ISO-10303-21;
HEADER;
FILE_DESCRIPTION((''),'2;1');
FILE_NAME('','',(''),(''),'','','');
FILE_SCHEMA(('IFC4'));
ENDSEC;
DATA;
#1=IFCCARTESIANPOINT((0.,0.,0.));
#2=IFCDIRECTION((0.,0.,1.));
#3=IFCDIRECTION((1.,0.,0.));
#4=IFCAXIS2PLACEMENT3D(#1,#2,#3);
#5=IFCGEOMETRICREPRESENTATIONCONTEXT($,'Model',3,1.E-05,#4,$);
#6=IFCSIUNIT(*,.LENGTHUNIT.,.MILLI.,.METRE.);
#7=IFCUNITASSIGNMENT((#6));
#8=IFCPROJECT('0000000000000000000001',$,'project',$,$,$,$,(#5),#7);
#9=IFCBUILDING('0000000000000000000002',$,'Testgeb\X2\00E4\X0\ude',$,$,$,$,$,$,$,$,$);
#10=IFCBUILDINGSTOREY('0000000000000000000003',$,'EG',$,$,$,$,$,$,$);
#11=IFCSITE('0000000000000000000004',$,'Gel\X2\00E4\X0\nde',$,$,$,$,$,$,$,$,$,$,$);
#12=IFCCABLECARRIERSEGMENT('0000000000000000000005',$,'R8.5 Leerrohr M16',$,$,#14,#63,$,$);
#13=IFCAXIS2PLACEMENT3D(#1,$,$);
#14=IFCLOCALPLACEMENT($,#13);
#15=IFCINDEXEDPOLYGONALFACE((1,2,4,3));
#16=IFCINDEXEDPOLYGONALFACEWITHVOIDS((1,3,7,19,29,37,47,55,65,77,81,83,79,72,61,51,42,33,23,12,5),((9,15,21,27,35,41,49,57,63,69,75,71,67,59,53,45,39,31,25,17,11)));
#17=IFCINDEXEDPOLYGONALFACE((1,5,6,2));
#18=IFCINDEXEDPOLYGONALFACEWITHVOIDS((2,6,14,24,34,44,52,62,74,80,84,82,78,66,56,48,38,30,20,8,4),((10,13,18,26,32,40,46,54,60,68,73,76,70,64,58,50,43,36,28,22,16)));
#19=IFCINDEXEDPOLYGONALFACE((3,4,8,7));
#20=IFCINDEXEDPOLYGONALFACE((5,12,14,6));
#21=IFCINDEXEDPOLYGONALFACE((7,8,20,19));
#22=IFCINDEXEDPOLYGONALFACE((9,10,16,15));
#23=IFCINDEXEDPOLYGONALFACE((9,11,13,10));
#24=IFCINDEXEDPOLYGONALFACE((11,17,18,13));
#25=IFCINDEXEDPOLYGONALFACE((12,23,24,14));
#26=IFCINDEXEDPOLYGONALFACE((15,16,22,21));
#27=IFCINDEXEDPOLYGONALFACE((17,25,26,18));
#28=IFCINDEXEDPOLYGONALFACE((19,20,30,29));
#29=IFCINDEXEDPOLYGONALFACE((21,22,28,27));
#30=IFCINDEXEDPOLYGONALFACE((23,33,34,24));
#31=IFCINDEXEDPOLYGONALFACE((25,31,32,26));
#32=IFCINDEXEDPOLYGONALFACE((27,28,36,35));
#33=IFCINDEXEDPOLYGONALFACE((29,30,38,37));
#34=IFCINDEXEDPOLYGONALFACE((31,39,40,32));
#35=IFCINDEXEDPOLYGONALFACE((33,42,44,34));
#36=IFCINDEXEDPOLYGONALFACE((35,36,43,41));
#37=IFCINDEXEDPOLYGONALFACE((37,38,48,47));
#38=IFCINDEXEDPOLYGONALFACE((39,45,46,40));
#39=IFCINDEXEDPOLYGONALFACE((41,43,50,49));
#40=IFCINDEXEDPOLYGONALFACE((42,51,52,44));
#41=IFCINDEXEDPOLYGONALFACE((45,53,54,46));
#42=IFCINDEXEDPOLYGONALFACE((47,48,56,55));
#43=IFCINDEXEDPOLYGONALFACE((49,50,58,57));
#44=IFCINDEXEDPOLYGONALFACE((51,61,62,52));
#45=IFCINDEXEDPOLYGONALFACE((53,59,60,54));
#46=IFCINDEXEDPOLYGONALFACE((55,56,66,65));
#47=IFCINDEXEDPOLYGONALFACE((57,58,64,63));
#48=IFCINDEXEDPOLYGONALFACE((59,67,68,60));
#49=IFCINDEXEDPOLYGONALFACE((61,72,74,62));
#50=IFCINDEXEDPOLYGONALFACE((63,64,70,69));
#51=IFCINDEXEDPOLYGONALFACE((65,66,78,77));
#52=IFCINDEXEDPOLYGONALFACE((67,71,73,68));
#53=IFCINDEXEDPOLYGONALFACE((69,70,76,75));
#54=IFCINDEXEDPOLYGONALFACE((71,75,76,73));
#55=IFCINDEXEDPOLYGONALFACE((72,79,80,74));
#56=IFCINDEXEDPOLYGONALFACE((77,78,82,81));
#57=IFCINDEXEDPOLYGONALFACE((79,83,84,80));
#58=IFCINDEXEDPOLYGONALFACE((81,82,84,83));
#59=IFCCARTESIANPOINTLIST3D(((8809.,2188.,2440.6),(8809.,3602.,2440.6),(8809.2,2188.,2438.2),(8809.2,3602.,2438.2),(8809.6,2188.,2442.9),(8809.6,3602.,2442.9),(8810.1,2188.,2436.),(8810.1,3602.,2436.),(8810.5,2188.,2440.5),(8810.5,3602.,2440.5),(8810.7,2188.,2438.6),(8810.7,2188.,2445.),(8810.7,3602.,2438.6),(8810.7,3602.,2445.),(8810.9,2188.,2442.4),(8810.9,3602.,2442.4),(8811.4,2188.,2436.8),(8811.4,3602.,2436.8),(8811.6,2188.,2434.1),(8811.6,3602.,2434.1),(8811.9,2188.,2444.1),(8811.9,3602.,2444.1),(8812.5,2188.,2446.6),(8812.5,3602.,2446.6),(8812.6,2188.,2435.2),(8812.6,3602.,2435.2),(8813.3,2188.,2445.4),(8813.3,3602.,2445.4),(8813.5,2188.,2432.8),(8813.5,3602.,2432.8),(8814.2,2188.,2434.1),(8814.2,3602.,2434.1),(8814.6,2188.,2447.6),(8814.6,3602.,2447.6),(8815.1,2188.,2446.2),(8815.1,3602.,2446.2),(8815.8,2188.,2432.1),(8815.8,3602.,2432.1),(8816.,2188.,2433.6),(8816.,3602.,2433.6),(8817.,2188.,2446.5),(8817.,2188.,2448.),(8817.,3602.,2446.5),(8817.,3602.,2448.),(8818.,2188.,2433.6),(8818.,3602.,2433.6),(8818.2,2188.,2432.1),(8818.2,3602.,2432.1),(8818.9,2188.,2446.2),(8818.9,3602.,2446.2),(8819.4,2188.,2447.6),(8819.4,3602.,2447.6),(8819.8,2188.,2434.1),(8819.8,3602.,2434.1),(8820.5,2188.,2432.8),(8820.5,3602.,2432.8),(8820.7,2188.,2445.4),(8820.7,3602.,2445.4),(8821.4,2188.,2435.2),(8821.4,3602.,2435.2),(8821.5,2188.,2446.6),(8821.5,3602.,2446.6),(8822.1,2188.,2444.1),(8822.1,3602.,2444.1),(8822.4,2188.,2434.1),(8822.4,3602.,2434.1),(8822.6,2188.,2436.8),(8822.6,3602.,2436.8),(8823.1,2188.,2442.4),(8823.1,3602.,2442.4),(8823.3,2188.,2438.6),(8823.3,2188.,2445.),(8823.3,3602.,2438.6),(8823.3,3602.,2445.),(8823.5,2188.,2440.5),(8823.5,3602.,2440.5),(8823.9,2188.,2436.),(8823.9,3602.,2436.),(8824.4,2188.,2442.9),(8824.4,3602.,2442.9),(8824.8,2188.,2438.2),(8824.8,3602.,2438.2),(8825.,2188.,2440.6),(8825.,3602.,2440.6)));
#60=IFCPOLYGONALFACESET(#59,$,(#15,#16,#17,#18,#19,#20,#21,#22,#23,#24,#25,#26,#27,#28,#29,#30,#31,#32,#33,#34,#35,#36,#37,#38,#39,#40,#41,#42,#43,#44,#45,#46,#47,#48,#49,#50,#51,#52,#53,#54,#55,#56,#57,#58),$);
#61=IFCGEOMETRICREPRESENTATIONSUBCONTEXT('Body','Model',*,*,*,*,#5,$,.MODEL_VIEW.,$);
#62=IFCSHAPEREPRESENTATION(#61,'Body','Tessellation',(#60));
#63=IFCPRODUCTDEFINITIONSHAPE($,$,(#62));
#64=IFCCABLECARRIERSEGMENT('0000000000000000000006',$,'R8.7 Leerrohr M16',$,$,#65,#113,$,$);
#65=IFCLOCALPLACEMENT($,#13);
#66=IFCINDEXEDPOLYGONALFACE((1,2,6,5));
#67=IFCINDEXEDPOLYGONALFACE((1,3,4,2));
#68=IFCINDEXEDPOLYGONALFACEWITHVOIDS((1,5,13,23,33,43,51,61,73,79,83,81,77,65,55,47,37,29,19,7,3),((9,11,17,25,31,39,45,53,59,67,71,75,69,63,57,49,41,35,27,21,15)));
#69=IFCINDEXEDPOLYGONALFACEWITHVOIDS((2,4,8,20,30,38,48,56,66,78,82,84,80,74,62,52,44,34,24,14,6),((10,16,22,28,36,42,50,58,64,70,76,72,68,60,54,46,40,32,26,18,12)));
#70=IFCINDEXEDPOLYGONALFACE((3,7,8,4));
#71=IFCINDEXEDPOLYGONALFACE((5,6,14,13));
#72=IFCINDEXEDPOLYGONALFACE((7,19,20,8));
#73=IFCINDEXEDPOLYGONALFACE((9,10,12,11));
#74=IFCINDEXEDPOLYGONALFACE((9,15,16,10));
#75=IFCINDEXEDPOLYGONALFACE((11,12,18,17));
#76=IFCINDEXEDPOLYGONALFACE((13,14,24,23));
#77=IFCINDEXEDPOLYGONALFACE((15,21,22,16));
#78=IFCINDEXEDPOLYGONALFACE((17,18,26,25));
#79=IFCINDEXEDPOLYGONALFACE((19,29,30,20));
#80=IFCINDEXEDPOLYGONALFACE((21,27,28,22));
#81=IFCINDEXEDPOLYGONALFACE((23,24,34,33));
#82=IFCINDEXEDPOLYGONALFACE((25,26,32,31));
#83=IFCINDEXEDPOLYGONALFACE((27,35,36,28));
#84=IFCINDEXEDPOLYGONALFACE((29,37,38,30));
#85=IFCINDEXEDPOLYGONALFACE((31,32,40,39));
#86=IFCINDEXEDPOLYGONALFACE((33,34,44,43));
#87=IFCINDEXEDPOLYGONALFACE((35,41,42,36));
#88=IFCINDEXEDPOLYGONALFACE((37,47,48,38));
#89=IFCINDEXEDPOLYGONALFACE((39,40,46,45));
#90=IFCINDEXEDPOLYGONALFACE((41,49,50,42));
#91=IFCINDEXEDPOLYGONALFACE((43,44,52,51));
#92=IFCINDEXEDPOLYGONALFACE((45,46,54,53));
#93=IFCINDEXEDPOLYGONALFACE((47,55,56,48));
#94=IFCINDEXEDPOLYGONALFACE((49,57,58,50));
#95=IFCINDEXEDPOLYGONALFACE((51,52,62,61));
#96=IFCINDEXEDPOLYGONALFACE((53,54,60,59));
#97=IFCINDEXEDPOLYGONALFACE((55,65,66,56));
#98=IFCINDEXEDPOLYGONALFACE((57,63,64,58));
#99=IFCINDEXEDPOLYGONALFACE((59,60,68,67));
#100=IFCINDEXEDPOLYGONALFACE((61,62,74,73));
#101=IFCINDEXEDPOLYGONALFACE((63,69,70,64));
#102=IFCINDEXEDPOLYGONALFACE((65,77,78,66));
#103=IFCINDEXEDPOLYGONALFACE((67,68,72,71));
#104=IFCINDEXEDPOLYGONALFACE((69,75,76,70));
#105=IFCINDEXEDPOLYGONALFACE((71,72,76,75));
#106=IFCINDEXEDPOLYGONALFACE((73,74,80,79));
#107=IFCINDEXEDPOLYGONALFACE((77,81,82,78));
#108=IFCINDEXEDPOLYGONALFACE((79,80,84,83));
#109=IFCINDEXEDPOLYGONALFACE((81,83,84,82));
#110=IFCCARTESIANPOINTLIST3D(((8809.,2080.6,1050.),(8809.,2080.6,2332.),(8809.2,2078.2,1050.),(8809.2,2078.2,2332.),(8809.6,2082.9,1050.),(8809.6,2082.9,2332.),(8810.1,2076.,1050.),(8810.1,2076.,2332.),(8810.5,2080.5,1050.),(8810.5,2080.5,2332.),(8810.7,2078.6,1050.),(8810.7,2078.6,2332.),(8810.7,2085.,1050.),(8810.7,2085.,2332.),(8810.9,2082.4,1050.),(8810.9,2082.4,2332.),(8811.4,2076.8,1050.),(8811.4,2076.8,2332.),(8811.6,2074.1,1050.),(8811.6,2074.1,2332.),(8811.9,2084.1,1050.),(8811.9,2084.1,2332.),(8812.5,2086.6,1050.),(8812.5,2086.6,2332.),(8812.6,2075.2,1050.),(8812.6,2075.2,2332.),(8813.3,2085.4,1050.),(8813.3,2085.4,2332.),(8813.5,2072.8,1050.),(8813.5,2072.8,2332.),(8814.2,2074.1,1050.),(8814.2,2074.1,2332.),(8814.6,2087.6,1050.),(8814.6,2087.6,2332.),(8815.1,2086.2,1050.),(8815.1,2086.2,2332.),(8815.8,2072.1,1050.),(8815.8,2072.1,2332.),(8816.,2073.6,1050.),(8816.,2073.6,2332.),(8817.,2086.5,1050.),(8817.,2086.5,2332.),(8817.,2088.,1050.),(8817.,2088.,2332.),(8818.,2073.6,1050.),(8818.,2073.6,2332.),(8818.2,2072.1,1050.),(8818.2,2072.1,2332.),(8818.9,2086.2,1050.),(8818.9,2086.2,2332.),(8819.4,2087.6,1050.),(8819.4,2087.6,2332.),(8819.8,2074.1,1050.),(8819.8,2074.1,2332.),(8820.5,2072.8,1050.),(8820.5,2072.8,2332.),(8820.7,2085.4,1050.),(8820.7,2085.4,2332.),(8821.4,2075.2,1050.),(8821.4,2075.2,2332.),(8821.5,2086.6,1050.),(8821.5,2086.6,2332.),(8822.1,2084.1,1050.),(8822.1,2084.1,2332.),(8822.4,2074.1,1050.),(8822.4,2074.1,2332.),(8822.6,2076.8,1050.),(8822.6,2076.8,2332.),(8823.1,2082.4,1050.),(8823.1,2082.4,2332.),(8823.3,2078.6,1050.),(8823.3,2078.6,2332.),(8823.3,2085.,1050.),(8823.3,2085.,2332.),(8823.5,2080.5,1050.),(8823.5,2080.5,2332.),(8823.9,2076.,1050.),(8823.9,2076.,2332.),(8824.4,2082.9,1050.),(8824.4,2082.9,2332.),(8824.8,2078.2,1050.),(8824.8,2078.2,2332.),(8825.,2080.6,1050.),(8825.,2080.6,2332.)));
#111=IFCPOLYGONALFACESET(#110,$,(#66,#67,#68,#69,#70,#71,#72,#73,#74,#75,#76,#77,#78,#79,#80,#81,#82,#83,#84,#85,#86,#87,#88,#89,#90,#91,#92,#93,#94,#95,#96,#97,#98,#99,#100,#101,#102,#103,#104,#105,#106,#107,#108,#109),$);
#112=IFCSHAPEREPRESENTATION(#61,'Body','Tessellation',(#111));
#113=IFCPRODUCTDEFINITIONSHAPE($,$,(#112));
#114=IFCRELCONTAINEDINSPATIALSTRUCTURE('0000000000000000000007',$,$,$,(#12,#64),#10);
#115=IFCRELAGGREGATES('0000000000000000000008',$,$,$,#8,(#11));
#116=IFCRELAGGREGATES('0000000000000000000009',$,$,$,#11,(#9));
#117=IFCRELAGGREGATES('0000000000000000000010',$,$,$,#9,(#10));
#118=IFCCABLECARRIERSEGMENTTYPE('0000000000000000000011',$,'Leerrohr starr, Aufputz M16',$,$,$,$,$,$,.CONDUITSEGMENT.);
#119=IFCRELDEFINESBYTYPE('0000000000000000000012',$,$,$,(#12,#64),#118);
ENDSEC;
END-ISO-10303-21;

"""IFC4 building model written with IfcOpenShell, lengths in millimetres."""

from ifc_helpers import new_model, si_unit, frame, origin_with_axes, place, context, subcontext, project, spatial, hollow_circle, extrude, type_object, element, save


model = new_model("IFC4")

# Units and contexts
model_context = context("Model", 3, precision=1e-05, world=origin_with_axes())
body_context = subcontext(model_context, "Body", "Model", "MODEL_VIEW")
ifc_project = project(units=[si_unit("LENGTHUNIT", "METRE", prefix="MILLI")], contexts=[model_context])

# Site, building, storey
site = spatial("IfcSite", under=ifc_project, Name="Gelände")
building = spatial("IfcBuilding", under=site, Name="Testgebäude")
storey = spatial("IfcBuildingStorey", under=building, Name="EG")

# Cable carrier segments
cable_carrier_segment_type_1 = type_object("IfcCableCarrierSegmentType", Name="Leerrohr starr, Aufputz M16", PredefinedType="CONDUITSEGMENT")
cable_carrier_segment_1_placement = place(None, frame((8817.0, 3602.0, 2440.0), z_axis=(0.0, -1.0, 0.0), x_axis=(0.0, 0.0, 1.0)))
element("IfcCableCarrierSegment", 1, at=cable_carrier_segment_1_placement, inside=storey, type_object=cable_carrier_segment_type_1, Name="R8.5 Leerrohr M16", context=body_context, shape_type="SweptSolid", body=[
    extrude(hollow_circle(Radius=8.0, WallThickness=1.5), None, (0.0, 0.0, 1.0), 1414.0),
])
cable_carrier_segment_2_placement = place(None, frame((8817.0, 2080.0, 2332.0), z_axis=(0.0, 0.0, -1.0), x_axis=(0.0, 1.0, 0.0)))
element("IfcCableCarrierSegment", 2, at=cable_carrier_segment_2_placement, inside=storey, type_object=cable_carrier_segment_type_1, Name="R8.7 Leerrohr M16", context=body_context, shape_type="SweptSolid", body=[
    extrude(hollow_circle(Radius=8.0, WallThickness=1.5), None, (0.0, 0.0, 1.0), 1282.0),
])

save(model, "model.ifc")
